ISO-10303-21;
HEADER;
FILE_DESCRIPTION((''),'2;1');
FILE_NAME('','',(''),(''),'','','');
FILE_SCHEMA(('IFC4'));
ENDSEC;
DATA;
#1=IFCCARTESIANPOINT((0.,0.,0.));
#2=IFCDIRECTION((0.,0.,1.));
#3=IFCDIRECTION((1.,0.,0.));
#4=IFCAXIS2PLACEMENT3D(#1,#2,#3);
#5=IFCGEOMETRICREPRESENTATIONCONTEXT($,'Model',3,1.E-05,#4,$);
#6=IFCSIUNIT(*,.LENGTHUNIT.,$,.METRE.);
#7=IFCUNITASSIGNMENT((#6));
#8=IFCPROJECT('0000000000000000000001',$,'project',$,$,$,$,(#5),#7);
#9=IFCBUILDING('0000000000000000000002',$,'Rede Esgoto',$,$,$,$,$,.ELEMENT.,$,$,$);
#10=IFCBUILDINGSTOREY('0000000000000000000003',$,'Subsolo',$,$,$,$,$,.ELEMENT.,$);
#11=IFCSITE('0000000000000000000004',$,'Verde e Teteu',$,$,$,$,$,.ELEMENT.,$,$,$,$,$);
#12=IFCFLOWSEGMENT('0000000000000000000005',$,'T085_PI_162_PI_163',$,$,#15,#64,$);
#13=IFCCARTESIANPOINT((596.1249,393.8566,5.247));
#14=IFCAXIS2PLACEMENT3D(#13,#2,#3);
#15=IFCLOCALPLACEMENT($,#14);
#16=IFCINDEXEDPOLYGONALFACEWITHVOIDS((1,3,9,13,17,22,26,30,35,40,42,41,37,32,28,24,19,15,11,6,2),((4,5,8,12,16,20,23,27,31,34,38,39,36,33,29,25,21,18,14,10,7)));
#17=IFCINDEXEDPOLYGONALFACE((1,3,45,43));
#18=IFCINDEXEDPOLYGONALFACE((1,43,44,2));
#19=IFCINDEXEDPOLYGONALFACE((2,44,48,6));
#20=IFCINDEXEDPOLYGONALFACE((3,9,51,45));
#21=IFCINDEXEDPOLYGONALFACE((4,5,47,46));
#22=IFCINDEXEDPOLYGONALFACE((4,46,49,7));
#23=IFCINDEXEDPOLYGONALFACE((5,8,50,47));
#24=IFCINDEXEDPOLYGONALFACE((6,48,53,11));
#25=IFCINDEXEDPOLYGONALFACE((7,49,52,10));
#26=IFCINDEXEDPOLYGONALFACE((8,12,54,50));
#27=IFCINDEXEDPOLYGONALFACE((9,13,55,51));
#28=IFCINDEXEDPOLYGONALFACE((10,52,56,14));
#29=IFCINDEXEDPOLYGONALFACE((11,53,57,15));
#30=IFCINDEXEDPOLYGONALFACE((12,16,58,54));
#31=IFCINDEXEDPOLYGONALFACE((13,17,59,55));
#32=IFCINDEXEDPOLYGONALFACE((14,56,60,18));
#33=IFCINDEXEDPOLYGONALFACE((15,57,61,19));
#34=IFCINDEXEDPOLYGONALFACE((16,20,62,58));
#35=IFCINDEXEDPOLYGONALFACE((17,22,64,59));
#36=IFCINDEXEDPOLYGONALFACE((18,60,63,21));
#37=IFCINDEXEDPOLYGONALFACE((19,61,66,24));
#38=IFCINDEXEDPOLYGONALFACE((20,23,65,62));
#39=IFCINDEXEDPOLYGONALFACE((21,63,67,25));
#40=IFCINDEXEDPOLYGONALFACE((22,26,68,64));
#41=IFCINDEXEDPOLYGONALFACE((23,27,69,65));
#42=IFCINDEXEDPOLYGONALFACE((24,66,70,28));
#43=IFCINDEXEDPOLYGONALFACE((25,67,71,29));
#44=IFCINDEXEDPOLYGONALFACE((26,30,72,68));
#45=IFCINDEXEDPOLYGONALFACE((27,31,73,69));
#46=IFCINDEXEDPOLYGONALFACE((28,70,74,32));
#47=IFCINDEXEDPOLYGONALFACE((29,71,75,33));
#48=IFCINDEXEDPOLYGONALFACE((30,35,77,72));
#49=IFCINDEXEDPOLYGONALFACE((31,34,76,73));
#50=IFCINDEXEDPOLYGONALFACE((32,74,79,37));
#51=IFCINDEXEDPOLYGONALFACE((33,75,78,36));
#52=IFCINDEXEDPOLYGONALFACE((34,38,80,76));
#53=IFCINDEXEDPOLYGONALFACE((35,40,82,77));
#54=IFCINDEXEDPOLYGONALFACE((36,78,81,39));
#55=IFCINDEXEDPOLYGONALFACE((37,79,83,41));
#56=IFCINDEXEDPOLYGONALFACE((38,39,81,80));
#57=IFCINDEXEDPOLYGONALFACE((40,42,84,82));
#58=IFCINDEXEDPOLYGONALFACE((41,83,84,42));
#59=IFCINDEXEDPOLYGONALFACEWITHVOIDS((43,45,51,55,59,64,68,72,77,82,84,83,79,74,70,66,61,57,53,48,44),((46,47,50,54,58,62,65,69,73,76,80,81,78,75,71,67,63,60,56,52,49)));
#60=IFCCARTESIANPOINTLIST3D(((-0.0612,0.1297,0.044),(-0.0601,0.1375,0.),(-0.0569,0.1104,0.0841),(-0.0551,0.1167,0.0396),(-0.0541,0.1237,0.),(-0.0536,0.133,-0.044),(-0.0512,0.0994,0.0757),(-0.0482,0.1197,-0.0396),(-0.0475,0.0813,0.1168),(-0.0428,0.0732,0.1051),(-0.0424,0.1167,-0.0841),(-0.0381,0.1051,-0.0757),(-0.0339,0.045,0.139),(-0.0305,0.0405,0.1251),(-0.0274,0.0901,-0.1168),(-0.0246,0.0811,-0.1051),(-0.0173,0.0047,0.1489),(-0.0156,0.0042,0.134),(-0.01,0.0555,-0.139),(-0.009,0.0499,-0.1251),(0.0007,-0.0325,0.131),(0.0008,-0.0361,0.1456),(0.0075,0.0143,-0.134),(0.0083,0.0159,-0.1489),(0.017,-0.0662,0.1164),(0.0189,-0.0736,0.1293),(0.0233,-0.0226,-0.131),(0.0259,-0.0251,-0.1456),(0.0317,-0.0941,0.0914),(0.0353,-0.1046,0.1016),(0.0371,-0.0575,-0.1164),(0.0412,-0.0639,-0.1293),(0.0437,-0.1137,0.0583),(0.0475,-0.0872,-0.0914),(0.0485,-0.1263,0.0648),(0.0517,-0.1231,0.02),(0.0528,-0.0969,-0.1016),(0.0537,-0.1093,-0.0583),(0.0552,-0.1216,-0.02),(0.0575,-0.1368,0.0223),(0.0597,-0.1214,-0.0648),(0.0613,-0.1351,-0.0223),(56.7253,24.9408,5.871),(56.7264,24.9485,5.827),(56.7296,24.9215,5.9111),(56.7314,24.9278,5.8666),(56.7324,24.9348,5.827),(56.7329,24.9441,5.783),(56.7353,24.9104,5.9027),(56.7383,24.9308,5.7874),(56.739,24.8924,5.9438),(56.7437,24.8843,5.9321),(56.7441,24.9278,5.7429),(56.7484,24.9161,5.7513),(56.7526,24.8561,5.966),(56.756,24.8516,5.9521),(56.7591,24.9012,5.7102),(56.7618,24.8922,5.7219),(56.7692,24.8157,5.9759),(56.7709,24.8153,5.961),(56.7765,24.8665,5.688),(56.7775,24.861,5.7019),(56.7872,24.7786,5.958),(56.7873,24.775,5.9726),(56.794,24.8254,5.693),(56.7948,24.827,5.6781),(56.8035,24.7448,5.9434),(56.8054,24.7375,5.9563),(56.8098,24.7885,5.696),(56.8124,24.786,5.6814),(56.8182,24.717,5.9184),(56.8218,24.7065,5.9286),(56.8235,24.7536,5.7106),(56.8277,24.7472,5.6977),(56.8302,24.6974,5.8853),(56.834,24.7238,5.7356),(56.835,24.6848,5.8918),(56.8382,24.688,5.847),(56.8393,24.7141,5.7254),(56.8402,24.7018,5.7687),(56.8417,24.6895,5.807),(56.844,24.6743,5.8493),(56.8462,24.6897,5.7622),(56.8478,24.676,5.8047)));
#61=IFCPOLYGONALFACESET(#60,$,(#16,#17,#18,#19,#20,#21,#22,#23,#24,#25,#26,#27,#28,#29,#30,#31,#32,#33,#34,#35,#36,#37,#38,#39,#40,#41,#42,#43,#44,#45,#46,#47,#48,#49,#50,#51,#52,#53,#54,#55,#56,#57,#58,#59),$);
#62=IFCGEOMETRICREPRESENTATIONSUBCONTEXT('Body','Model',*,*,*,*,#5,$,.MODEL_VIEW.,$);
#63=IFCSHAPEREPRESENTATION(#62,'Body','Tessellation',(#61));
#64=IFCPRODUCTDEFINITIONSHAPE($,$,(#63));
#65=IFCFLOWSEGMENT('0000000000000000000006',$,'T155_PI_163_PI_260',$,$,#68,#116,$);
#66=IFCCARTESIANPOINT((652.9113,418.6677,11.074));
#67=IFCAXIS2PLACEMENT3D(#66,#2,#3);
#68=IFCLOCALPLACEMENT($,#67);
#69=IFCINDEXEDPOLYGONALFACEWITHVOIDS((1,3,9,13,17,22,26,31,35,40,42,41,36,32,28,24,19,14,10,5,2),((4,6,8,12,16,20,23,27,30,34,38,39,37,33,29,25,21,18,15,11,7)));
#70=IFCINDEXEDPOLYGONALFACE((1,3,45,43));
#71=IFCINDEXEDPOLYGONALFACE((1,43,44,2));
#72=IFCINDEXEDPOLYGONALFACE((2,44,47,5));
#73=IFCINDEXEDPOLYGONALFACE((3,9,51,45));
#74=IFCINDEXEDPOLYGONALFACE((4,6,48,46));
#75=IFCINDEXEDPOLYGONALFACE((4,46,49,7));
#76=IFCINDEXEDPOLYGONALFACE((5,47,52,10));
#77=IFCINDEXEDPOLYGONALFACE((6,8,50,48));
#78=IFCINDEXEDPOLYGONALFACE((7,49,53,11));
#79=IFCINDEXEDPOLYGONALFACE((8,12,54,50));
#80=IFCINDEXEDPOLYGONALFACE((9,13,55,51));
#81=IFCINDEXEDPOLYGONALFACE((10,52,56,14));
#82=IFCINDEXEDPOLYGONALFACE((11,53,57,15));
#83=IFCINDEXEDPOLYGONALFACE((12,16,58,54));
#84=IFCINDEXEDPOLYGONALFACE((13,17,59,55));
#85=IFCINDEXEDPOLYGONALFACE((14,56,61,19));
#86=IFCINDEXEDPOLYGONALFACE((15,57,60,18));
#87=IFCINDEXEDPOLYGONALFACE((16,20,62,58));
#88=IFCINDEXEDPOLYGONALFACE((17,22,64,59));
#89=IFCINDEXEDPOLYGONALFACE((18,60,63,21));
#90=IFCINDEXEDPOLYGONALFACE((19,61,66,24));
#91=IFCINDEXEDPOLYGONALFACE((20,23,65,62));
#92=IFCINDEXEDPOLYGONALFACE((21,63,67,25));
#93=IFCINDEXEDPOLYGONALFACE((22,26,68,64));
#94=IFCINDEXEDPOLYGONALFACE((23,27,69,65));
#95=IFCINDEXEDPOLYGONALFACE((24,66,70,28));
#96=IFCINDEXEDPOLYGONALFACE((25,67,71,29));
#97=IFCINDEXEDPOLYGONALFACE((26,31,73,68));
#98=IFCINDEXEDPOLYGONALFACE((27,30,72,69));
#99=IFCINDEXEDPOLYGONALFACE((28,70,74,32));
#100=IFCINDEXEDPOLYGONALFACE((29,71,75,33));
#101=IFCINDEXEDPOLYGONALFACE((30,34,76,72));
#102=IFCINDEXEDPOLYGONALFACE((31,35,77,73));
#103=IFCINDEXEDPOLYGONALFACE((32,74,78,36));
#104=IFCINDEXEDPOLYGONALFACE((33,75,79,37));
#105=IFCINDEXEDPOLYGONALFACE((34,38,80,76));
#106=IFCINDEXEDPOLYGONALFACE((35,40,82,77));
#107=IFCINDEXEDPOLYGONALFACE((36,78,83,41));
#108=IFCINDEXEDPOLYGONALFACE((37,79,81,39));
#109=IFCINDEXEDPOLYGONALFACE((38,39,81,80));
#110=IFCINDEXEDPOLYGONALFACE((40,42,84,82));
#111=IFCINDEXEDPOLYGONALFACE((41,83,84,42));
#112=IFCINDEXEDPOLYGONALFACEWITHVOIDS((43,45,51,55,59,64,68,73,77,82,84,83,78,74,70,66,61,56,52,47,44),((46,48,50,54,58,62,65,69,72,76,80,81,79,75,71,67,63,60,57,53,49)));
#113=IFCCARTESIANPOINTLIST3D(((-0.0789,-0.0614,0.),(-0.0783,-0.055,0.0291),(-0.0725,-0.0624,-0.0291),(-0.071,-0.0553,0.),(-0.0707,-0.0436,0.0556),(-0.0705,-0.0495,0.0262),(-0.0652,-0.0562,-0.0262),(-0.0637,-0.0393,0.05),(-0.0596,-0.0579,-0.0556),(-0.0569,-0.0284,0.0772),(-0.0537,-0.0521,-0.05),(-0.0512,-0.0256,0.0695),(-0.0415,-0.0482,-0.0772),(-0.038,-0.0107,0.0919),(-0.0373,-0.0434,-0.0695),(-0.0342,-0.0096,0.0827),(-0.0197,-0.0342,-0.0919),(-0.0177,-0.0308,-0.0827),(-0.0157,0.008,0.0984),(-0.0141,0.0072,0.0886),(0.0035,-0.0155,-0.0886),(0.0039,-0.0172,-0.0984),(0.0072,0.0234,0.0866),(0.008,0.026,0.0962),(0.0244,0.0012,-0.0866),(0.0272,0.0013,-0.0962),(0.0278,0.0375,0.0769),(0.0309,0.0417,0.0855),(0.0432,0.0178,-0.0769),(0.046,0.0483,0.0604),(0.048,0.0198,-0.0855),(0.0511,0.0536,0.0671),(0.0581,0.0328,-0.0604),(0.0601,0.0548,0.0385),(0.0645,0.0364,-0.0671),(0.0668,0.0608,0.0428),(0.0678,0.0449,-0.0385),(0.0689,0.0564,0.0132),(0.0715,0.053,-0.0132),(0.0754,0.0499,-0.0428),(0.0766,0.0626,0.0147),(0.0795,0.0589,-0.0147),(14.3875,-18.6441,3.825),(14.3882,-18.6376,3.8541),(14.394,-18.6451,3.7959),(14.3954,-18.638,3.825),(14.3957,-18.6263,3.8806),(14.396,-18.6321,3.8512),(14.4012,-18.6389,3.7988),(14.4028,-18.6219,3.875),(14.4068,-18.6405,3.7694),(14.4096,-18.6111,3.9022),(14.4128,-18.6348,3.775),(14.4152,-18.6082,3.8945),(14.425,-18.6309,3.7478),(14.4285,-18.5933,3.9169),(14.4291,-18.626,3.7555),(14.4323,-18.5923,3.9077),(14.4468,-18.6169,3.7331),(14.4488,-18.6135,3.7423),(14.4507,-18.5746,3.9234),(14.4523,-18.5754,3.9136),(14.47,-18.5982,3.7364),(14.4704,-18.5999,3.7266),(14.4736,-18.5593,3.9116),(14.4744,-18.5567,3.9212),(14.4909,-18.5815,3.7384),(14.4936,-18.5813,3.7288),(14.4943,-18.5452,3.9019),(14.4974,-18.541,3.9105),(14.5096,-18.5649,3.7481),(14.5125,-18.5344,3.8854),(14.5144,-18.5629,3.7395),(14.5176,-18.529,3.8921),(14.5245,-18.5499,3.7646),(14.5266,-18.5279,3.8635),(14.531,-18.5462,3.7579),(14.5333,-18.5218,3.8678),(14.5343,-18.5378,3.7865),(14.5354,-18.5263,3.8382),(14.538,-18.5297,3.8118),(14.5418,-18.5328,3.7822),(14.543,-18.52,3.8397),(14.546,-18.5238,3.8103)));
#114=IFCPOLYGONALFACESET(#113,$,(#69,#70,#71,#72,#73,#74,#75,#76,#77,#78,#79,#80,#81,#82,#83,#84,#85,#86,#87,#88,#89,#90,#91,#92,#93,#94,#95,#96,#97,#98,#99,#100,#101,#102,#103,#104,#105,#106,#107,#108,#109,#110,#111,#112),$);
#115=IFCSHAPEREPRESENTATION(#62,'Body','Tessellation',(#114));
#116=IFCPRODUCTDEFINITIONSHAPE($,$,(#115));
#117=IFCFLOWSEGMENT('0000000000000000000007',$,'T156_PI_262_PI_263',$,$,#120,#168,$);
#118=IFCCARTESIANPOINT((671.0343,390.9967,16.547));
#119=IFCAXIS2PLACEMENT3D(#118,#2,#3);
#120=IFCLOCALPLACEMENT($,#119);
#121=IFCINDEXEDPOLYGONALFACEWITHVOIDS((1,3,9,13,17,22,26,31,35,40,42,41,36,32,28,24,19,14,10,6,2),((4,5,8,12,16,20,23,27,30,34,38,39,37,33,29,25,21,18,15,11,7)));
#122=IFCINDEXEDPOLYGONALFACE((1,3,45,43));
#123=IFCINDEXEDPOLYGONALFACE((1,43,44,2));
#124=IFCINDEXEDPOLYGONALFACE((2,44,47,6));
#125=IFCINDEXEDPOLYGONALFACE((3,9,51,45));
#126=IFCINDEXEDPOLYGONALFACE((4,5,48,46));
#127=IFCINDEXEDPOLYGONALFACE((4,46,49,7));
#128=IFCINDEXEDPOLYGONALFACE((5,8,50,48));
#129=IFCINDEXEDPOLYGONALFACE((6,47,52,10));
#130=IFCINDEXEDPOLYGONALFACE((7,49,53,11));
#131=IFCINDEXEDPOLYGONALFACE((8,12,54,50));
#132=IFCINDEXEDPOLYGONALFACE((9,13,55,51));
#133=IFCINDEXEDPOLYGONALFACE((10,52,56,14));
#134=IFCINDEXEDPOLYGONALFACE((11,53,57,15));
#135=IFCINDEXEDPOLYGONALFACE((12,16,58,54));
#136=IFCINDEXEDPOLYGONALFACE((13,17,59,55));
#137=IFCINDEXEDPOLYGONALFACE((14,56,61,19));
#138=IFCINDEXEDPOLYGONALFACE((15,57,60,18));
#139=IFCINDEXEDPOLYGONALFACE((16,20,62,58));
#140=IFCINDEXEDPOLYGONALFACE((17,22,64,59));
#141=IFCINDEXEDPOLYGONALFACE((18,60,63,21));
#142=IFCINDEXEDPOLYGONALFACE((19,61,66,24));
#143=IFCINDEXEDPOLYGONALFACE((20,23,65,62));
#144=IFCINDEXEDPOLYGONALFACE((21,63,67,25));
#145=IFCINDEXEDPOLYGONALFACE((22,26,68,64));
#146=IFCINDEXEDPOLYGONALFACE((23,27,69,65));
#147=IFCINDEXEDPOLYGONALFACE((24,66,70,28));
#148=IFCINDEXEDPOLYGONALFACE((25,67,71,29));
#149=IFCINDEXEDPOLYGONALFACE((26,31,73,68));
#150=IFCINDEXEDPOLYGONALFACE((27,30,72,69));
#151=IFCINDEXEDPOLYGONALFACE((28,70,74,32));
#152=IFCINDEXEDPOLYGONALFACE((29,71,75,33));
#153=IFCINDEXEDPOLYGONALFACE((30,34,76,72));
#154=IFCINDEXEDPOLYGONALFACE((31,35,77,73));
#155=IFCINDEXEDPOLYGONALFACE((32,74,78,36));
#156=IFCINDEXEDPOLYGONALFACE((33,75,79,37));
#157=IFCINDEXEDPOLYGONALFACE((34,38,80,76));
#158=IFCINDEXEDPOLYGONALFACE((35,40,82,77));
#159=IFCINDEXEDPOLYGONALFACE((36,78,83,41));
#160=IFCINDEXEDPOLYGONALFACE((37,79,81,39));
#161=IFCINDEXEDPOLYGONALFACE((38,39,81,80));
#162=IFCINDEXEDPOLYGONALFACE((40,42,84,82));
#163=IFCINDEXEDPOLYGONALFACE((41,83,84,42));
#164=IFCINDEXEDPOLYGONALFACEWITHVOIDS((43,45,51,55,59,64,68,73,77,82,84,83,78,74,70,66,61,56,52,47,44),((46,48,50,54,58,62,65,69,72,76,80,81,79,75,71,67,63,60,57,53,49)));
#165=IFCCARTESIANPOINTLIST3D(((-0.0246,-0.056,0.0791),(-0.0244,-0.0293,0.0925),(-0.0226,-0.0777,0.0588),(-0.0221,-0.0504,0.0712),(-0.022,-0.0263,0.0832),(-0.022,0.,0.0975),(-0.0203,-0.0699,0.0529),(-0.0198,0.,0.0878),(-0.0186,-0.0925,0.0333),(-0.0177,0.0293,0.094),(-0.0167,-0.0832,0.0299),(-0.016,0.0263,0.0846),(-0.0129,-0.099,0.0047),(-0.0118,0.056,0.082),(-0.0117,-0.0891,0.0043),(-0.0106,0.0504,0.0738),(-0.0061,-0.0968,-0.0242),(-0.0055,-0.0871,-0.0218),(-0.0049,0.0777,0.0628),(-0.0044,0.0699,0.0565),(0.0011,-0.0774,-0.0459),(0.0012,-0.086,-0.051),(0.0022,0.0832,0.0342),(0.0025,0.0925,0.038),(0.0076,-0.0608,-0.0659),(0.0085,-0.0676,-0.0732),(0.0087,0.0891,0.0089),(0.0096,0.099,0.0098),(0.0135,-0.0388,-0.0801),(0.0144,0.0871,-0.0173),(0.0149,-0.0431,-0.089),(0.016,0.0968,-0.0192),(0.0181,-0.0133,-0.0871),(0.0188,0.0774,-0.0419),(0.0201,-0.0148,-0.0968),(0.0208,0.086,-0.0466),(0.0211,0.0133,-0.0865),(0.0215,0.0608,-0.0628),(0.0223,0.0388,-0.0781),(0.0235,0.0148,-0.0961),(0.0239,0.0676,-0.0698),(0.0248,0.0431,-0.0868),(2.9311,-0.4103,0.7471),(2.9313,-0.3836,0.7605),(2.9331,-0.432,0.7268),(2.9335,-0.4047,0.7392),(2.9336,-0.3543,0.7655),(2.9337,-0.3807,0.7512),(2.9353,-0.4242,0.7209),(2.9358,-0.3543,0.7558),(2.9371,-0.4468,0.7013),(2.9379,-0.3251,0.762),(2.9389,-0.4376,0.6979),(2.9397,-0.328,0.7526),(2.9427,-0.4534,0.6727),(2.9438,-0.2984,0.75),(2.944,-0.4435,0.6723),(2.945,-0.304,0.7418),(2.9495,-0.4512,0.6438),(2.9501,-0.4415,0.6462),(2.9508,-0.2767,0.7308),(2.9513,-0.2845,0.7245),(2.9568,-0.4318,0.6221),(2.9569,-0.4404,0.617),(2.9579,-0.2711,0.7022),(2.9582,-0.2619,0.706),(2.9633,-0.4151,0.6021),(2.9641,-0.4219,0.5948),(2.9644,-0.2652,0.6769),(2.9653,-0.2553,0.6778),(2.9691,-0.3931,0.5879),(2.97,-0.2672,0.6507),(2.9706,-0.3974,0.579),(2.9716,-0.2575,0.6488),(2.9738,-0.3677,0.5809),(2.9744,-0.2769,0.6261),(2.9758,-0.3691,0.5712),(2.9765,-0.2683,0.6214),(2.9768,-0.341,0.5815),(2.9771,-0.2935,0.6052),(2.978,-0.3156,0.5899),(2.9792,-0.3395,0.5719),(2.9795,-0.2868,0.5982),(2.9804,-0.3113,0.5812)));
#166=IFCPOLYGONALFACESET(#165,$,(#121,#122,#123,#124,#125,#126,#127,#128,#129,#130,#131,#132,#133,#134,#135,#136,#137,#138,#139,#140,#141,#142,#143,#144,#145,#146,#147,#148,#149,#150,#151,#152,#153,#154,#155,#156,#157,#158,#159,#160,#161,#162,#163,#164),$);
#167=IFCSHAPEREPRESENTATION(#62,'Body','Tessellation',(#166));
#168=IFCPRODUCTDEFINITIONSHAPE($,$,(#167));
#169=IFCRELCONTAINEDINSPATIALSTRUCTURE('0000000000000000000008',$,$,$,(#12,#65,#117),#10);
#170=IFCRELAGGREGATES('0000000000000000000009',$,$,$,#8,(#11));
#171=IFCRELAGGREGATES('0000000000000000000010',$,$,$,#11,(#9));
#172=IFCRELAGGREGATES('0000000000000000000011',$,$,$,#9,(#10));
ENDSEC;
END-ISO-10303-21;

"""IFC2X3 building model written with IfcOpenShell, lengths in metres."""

from ifc_helpers import new_model, entity, si_unit, frame, origin_with_axes, place, context, subcontext, project, spatial, element, save


model = new_model("IFC2X3")

# Units and contexts
model_context = context("Model", 3, precision=1e-05, world=origin_with_axes())
body_context = subcontext(model_context, "Body", "Model", "MODEL_VIEW")
ifc_project = project(units=[si_unit("LENGTHUNIT", "METRE")], contexts=[model_context])

# Site, building, storey
site = spatial("IfcSite", under=ifc_project, Name="Verde e Teteu", CompositionType="ELEMENT")
building = spatial("IfcBuilding", under=site, Name="Rede Esgoto", CompositionType="ELEMENT")
storey = spatial("IfcBuildingStorey", under=building, Name="Subsolo", CompositionType="ELEMENT")

# Flow segments
flow_segment_1_placement = place(None, frame((596.1249, 393.8566, 5.247), z_axis=(0.0, 0.0, 1.0), x_axis=(1.0, 0.0, 0.0)))
element("IfcFlowSegment", 1, at=flow_segment_1_placement, inside=storey, Name="T085_PI_162_PI_163", context=body_context, shape_type="SweptSolid", body=[
    entity("IfcSweptDiskSolid", entity("IfcPolyline", [entity("IfcCartesianPoint", [0.0, 0.0, 0.0]), entity("IfcCartesianPoint", [56.7865, 24.8111, 5.827])]), 0.15, 0.135),
])
flow_segment_2_placement = place(None, frame((652.9113, 418.6677, 11.074), z_axis=(0.0, 0.0, 1.0), x_axis=(1.0, 0.0, 0.0)))
element("IfcFlowSegment", 2, at=flow_segment_2_placement, inside=storey, Name="T155_PI_163_PI_260", context=body_context, shape_type="SweptSolid", body=[
    entity("IfcSweptDiskSolid", entity("IfcPolyline", [entity("IfcCartesianPoint", [0.0, 0.0, 0.0]), entity("IfcCartesianPoint", [14.4665, -18.5827, 3.825])]), 0.1, 0.09),
])
flow_segment_3_placement = place(None, frame((671.0343, 390.9967, 16.547), z_axis=(0.0, 0.0, 1.0), x_axis=(1.0, 0.0, 0.0)))
element("IfcFlowSegment", 3, at=flow_segment_3_placement, inside=storey, Name="T156_PI_262_PI_263", context=body_context, shape_type="SweptSolid", body=[
    entity("IfcSweptDiskSolid", entity("IfcPolyline", [entity("IfcCartesianPoint", [0.0, 0.0, 0.0]), entity("IfcCartesianPoint", [2.9557, -0.3543, 0.668])]), 0.1, 0.09),
])

save(model, "model.ifc")
